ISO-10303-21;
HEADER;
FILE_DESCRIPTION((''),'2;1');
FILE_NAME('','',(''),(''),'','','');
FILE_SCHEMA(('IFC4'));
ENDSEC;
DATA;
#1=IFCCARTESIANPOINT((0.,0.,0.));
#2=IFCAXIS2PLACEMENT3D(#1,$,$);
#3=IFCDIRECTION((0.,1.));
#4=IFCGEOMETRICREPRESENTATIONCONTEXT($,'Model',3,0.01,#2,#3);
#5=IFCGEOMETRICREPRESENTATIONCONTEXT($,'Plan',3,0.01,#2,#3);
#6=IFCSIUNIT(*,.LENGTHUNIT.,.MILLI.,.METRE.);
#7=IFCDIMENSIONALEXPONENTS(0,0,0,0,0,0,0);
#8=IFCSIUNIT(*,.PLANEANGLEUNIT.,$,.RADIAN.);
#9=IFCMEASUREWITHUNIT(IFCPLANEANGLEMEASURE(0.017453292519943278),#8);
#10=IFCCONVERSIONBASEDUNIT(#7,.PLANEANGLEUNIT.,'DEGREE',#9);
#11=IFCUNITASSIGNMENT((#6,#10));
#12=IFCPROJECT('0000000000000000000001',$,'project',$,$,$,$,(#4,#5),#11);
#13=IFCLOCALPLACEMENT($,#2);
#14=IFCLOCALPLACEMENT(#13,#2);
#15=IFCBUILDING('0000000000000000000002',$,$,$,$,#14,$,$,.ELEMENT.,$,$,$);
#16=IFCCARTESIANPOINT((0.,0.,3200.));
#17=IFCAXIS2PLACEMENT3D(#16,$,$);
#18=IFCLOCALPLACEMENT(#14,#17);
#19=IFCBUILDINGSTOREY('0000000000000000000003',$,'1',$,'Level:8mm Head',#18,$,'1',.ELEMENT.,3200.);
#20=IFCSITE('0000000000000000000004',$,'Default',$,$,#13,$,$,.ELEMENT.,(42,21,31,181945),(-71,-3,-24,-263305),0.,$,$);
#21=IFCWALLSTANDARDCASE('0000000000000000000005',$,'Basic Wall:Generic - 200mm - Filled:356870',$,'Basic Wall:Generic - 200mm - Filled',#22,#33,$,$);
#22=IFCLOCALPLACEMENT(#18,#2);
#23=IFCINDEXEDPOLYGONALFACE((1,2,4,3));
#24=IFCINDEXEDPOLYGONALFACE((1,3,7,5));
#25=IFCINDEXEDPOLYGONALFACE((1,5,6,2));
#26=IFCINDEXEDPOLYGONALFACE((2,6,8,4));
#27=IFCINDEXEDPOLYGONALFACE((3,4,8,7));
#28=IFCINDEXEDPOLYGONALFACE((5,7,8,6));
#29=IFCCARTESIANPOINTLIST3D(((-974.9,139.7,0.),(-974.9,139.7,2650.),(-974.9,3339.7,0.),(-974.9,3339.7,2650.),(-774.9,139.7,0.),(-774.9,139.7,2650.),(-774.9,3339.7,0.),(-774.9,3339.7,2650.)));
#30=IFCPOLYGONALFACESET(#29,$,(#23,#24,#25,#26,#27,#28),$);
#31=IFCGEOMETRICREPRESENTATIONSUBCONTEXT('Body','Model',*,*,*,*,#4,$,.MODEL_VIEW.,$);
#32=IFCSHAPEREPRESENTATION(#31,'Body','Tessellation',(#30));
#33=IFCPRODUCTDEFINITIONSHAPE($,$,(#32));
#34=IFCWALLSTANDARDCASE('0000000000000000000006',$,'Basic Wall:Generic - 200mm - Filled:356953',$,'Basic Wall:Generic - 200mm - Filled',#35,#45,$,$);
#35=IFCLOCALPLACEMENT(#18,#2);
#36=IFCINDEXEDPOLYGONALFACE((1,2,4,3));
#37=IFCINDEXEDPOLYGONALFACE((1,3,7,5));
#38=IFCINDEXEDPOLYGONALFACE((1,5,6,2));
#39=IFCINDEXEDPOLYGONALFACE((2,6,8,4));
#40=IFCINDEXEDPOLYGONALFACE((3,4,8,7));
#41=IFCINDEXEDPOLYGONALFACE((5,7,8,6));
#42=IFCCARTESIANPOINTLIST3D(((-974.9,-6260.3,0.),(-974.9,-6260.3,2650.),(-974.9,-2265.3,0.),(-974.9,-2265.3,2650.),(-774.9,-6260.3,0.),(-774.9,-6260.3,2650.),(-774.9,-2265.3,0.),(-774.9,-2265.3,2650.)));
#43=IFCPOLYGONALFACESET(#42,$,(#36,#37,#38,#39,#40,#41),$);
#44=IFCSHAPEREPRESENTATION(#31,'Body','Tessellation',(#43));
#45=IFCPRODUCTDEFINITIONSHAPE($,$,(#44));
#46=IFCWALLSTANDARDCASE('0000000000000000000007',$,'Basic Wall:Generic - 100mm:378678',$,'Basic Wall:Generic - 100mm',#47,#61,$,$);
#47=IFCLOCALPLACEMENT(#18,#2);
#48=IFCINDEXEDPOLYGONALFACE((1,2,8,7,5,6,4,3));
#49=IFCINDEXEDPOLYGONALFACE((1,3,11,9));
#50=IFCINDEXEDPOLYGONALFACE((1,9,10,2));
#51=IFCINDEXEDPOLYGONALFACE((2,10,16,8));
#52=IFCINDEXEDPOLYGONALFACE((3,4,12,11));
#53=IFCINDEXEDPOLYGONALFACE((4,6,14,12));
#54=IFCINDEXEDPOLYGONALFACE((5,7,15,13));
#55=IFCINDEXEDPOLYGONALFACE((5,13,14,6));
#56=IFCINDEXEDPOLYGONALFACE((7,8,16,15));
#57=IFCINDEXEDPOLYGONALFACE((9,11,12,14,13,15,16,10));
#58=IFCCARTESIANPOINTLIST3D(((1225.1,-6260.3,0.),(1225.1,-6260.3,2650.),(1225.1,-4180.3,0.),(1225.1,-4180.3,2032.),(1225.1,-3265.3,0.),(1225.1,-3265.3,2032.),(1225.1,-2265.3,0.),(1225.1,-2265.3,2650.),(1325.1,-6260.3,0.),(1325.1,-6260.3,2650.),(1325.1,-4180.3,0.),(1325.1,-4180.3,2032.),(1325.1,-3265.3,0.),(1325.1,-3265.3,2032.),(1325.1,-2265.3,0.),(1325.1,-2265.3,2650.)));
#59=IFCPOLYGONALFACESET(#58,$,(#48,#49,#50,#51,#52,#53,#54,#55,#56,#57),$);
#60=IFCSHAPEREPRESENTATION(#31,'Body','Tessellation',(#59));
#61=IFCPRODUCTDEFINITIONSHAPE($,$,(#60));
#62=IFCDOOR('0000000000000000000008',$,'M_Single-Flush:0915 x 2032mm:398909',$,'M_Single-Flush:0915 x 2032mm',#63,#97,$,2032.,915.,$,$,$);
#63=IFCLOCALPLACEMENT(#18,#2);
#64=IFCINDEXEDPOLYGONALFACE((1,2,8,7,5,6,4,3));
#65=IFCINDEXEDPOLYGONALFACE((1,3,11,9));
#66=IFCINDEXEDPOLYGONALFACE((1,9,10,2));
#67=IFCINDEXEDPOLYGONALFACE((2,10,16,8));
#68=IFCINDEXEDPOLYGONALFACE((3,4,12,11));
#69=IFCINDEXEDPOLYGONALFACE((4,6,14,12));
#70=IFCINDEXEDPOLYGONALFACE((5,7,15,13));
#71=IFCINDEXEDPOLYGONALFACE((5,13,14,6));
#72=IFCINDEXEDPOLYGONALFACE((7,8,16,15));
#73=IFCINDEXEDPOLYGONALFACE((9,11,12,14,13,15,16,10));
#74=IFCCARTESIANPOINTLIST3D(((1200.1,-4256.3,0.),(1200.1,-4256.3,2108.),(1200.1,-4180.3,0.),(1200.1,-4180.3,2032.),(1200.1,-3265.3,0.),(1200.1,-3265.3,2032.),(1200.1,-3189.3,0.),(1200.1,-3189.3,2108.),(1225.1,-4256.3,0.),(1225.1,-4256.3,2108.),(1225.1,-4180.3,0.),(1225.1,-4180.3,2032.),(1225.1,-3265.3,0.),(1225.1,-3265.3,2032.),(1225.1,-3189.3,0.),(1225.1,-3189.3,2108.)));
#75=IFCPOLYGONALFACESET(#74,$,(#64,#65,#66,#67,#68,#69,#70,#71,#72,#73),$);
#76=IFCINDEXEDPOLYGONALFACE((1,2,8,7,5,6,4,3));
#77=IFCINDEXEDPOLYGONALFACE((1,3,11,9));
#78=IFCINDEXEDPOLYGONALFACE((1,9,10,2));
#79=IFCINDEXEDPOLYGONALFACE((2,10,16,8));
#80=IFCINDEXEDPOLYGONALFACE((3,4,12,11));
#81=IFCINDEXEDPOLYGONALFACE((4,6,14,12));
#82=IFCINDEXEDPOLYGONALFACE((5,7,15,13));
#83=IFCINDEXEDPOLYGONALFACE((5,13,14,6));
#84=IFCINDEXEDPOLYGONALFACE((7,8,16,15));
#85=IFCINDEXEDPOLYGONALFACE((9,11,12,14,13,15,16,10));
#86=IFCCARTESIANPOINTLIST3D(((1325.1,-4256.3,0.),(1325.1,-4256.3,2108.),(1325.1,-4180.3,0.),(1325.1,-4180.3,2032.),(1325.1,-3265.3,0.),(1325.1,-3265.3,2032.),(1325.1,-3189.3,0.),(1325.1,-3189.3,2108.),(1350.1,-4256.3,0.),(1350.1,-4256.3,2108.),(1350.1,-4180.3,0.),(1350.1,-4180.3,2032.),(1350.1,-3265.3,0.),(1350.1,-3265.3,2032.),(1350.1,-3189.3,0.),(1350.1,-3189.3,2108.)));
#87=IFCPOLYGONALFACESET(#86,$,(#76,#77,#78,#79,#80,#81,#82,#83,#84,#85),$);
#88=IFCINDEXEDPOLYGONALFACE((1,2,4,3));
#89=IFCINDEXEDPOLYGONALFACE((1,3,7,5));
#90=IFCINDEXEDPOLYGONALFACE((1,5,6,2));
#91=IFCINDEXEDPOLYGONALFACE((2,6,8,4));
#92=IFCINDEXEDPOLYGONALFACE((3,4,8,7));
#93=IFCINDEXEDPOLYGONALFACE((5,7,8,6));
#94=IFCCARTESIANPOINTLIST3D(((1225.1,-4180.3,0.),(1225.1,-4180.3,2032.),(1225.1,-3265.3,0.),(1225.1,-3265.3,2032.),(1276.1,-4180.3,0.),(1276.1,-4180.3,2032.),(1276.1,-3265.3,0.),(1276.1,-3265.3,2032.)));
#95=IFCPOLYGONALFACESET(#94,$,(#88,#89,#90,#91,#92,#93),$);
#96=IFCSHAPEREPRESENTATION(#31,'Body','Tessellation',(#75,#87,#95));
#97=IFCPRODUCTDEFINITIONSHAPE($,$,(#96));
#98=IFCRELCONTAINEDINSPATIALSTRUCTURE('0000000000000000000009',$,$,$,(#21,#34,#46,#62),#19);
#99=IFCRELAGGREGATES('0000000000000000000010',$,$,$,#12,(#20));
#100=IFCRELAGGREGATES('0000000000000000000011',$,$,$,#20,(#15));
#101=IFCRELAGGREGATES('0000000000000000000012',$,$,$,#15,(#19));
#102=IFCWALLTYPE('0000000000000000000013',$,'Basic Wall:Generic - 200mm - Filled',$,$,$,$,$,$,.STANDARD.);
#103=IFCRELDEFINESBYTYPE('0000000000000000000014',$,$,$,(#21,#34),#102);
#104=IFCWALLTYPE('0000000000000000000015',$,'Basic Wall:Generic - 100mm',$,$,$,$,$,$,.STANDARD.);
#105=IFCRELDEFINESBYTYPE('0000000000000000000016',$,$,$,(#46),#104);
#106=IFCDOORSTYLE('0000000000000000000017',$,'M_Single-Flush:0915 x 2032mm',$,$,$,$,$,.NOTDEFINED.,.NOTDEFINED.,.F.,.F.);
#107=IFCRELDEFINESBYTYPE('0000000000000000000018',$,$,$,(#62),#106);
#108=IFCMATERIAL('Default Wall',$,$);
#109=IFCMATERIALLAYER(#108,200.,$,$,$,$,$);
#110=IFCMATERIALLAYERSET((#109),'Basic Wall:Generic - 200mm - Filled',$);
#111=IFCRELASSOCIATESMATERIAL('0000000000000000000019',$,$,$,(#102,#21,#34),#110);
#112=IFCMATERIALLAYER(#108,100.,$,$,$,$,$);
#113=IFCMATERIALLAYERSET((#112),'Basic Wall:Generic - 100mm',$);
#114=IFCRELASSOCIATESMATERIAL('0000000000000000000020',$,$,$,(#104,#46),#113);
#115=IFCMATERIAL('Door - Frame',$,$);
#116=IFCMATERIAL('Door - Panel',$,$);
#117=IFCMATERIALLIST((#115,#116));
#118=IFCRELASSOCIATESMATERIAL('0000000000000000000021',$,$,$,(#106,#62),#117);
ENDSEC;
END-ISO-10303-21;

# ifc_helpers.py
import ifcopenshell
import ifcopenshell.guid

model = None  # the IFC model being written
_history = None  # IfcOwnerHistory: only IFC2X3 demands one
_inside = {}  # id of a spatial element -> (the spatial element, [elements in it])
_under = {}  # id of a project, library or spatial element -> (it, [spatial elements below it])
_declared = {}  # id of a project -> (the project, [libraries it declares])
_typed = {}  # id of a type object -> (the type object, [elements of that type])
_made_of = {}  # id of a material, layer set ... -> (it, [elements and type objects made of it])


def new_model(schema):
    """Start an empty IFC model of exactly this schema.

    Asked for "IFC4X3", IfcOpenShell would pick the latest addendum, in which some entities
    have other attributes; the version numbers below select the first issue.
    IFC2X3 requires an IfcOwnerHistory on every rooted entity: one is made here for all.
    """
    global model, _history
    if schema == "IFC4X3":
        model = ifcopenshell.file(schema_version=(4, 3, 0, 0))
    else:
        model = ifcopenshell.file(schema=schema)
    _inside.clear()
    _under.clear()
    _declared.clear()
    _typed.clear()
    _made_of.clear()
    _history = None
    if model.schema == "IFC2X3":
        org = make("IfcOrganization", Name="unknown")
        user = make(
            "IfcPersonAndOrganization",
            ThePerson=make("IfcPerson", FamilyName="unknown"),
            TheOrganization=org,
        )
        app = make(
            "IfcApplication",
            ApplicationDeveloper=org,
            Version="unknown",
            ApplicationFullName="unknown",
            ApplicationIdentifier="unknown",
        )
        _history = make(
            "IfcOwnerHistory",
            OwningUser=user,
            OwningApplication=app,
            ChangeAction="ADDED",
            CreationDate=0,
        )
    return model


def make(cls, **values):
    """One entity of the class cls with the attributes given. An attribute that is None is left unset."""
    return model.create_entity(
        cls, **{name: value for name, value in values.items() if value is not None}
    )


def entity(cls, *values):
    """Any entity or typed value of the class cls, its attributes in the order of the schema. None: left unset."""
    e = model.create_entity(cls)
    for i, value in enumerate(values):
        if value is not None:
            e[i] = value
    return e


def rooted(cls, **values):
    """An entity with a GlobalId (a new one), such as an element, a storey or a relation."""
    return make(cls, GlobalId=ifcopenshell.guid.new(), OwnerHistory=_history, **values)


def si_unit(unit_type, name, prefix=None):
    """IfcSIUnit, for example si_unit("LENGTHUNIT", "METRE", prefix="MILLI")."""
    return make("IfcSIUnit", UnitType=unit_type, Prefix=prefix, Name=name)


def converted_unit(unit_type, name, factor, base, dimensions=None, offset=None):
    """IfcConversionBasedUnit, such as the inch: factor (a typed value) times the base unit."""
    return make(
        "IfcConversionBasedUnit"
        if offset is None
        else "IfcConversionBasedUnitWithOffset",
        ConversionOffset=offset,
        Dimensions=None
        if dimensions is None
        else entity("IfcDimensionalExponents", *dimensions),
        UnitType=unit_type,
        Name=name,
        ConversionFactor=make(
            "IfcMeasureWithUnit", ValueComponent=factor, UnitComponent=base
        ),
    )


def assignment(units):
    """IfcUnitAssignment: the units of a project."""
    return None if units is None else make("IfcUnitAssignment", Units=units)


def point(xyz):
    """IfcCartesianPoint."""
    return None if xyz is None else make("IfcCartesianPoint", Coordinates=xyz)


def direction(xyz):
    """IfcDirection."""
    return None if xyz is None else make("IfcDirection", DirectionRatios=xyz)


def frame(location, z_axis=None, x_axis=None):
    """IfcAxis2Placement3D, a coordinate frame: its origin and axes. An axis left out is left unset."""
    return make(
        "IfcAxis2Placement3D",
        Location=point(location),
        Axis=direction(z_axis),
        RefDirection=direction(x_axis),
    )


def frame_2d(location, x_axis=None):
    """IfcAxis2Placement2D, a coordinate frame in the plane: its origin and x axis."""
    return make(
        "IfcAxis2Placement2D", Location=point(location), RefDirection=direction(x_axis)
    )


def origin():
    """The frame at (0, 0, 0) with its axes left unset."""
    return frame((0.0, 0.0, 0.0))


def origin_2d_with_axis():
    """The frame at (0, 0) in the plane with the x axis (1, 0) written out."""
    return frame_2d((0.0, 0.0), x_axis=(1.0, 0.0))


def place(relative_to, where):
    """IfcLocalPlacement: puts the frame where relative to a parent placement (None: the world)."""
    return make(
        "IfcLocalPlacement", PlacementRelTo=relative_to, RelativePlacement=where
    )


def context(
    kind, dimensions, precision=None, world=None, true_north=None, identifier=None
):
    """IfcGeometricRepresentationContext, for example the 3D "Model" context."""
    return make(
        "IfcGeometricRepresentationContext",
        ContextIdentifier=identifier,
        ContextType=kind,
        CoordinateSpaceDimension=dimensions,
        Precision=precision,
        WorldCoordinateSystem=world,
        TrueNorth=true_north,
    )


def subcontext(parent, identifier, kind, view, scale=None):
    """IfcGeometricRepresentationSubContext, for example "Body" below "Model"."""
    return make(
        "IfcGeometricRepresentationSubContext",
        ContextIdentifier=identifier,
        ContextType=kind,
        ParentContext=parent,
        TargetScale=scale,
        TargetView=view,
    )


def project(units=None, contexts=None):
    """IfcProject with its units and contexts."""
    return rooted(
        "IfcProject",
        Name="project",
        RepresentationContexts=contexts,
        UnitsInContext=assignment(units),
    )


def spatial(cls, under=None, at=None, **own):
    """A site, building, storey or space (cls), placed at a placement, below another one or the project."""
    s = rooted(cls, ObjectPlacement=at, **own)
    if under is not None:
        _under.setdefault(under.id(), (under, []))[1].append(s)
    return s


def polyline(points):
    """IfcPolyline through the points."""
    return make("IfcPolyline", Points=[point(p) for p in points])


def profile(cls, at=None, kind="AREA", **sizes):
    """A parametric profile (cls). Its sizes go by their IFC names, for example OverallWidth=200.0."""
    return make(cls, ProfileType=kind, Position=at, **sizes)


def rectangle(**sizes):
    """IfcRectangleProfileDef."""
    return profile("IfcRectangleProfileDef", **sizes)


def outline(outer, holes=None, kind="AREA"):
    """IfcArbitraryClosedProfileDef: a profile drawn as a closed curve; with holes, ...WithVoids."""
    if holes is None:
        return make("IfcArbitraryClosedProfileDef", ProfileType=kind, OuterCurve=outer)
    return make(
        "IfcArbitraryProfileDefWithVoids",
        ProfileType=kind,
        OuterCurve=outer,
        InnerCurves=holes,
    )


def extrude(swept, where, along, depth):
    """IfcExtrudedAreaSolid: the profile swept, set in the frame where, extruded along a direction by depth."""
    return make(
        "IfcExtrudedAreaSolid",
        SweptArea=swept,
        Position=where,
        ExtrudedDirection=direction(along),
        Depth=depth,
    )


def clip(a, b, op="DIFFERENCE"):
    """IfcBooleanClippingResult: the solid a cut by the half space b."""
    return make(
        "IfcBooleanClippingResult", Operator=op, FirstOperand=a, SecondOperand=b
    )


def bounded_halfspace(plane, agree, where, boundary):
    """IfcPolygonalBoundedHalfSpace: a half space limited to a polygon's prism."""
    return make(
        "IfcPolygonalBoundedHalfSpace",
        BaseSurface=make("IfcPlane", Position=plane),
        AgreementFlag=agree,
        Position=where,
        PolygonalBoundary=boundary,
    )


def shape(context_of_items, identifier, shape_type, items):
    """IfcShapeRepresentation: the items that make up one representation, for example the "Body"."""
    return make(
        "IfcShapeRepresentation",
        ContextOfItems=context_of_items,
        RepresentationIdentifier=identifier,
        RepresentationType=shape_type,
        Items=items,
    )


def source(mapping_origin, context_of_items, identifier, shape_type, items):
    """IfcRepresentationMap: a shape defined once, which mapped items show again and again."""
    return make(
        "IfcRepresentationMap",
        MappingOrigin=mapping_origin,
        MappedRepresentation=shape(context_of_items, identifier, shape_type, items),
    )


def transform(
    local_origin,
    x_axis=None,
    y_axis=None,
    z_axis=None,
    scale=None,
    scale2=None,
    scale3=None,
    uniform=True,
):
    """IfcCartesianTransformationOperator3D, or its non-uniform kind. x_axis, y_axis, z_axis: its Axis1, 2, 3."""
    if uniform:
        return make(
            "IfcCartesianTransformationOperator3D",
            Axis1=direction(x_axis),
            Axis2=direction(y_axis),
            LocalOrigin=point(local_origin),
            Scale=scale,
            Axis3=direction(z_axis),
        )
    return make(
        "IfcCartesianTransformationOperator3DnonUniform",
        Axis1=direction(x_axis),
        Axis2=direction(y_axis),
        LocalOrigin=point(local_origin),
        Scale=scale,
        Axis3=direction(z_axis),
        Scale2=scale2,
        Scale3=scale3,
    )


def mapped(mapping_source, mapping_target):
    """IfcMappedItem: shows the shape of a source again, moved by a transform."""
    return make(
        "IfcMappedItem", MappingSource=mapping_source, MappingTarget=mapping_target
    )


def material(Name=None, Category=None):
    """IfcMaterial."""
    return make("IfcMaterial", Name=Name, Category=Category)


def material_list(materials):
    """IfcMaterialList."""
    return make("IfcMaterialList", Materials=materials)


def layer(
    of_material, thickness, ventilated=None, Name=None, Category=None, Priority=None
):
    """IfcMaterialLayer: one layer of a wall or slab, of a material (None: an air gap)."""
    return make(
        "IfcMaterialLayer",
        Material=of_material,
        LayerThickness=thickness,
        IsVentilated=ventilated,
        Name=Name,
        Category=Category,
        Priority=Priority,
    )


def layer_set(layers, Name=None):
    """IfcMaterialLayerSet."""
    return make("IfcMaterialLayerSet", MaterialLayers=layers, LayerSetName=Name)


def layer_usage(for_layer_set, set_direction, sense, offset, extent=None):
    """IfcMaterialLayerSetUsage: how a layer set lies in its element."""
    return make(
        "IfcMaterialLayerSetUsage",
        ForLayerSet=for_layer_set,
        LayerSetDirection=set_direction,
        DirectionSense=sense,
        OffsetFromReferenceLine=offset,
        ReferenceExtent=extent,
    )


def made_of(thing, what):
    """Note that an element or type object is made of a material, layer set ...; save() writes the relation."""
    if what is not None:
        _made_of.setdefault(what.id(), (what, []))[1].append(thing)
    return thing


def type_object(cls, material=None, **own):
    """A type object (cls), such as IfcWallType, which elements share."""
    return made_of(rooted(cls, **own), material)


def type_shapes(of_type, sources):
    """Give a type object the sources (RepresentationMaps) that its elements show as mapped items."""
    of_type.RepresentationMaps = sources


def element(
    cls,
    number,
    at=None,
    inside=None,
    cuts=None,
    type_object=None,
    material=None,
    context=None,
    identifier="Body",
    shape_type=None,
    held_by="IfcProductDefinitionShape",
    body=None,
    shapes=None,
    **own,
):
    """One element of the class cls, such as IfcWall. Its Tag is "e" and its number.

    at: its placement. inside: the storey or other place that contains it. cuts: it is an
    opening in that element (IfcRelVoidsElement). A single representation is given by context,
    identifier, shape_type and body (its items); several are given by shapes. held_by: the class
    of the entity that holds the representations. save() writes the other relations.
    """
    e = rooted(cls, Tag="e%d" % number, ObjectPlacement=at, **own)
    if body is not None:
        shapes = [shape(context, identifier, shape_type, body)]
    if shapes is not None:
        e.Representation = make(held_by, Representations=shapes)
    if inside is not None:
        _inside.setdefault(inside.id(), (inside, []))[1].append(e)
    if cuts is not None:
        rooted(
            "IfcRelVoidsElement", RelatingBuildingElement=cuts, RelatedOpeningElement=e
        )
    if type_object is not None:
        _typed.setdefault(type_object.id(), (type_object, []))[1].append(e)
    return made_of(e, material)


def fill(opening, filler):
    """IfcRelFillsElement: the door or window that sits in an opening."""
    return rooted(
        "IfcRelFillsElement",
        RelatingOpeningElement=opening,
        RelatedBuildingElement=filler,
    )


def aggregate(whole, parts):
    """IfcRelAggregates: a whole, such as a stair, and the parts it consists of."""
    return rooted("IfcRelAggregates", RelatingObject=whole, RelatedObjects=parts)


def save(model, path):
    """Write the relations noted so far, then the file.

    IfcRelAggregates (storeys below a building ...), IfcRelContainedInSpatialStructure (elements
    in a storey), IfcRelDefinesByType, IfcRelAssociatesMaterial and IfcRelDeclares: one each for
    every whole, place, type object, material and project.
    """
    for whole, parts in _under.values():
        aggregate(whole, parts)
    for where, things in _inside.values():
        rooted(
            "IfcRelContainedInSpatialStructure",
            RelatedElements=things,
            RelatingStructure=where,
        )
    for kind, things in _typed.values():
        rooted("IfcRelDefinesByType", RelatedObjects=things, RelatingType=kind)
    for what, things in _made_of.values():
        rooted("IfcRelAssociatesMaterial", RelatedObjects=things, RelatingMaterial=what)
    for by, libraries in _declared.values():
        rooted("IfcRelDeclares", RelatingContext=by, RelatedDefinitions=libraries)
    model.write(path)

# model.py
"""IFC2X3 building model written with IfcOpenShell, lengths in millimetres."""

from ifc_helpers import new_model, entity, si_unit, converted_unit, direction, frame, frame_2d, origin, origin_2d_with_axis, place, context, subcontext, project, spatial, polyline, rectangle, outline, extrude, clip, bounded_halfspace, source, transform, mapped, material, material_list, layer, layer_set, layer_usage, type_object, type_shapes, element, fill, save


model = new_model("IFC2X3")

# Units and contexts
model_context = context("Model", 3, precision=0.01, world=origin(), true_north=direction((0.0, 1.0)))
plan_context = context("Plan", 3, precision=0.01, world=origin(), true_north=direction((0.0, 1.0)))
body_context = subcontext(model_context, "Body", "Model", "MODEL_VIEW")
ifc_project = project(units=[si_unit("LENGTHUNIT", "METRE", prefix="MILLI"), converted_unit("PLANEANGLEUNIT", "DEGREE", entity("IfcPlaneAngleMeasure", 0.017453292519943278), si_unit("PLANEANGLEUNIT", "RADIAN"), dimensions=[0, 0, 0, 0, 0, 0, 0])], contexts=[model_context, plan_context])

# Site, building, storey
site_placement = place(None, origin())
site = spatial("IfcSite", under=ifc_project, at=site_placement, Name="Default", CompositionType="ELEMENT", RefLatitude=(42, 21, 31, 181945), RefLongitude=(-71, -3, -24, -263305), RefElevation=0.0)
building_placement = place(site_placement, origin())
building = spatial("IfcBuilding", under=site, at=building_placement, CompositionType="ELEMENT")
storey_placement = place(building_placement, frame((0.0, 0.0, 3200.0)))
storey = spatial("IfcBuildingStorey", under=building, at=storey_placement, Name="1", ObjectType="Level:8mm Head", LongName="1", CompositionType="ELEMENT", Elevation=3200.0)

# Shared definitions
ifc_material_1 = material(Name="Default Wall")
ifc_layer_1 = layer(ifc_material_1, 200.0)
ifc_layer_set_1 = layer_set([ifc_layer_1], Name="Basic Wall:Generic - 200mm - Filled")
ifc_layer_usage_1 = layer_usage(ifc_layer_set_1, "AXIS2", "NEGATIVE", 100.0)
wall_type_1 = type_object("IfcWallType", Name="Basic Wall:Generic - 200mm - Filled", PredefinedType="STANDARD", material=ifc_layer_set_1)
ifc_material_2 = material(Name="Door - Frame")
ifc_material_3 = material(Name="Door - Panel")
ifc_material_list = material_list([ifc_material_2, ifc_material_3])

# Walls
wall_1_placement = place(storey_placement, frame((-874.9, 3339.7, 0.0), z_axis=(0.0, 0.0, 1.0), x_axis=(0.0, -1.0, 0.0)))
element("IfcWallStandardCase", 1, at=wall_1_placement, inside=storey, type_object=wall_type_1, material=ifc_layer_usage_1, Name="Basic Wall:Generic - 200mm - Filled:356870", ObjectType="Basic Wall:Generic - 200mm - Filled", context=body_context, shape_type="Clipping", body=[
    clip(extrude(rectangle(XDim=3200.0, YDim=200.0, at=frame_2d((1600.0, 0.0), x_axis=(-1.0, 0.0))), origin(), (0.0, 0.0, 1.0), 2650.0), bounded_halfspace(frame((0.0, -100.0, 2650.0), z_axis=(0.0, 0.0, -1.0), x_axis=(1.0, 0.0, 0.0)), True, frame((0.0, -100.0, 2650.0)), polyline([(0.0, 0.0), (3200.0, 0.0), (3200.0, 200.0), (0.0, 200.0), (0.0, 0.0)]))),
])
wall_2_placement = place(storey_placement, frame((-874.9, -2265.3, 0.0), z_axis=(0.0, 0.0, 1.0), x_axis=(0.0, -1.0, 0.0)))
element("IfcWallStandardCase", 2, at=wall_2_placement, inside=storey, type_object=wall_type_1, material=ifc_layer_usage_1, Name="Basic Wall:Generic - 200mm - Filled:356953", ObjectType="Basic Wall:Generic - 200mm - Filled", context=body_context, shape_type="Clipping", body=[
    clip(extrude(rectangle(XDim=3995.0, YDim=200.0, at=frame_2d((1997.5, 0.0), x_axis=(-1.0, 0.0))), origin(), (0.0, 0.0, 1.0), 2650.0), bounded_halfspace(frame((3995.0, 0.0, 2650.0), z_axis=(0.0, 0.0, -1.0), x_axis=(1.0, 0.0, 0.0)), True, frame((3995.0, 0.0, 2650.0)), polyline([(0.0, 0.0), (0.0, 100.0), (-3995.0, 100.0), (-3995.0, 0.0), (-3995.0, -100.0), (-2995.0, -100.0), (-2995.0, 0.0), (0.0, 0.0)]))),
])

# Wall, opening, door
ifc_layer_2 = layer(ifc_material_1, 100.0)
ifc_layer_set_2 = layer_set([ifc_layer_2], Name="Basic Wall:Generic - 100mm")
ifc_layer_usage_2 = layer_usage(ifc_layer_set_2, "AXIS2", "NEGATIVE", 50.0)
wall_type_2 = type_object("IfcWallType", Name="Basic Wall:Generic - 100mm", PredefinedType="STANDARD", material=ifc_layer_set_2)
wall_3_placement = place(storey_placement, frame((1275.1, -2265.3, 0.0), z_axis=(0.0, 0.0, 1.0), x_axis=(0.0, -1.0, 0.0)))
wall_3 = element("IfcWallStandardCase", 3, at=wall_3_placement, inside=storey, type_object=wall_type_2, material=ifc_layer_usage_2, Name="Basic Wall:Generic - 100mm:378678", ObjectType="Basic Wall:Generic - 100mm", context=body_context, shape_type="Clipping", body=[
    clip(extrude(rectangle(XDim=3995.0, YDim=100.0, at=frame_2d((1997.5, 0.0), x_axis=(-1.0, 0.0))), origin(), (0.0, 0.0, 1.0), 2650.0), bounded_halfspace(frame((0.0, -50.0, 2650.0), z_axis=(0.0, 0.0, -1.0), x_axis=(1.0, 0.0, 0.0)), True, frame((0.0, -50.0, 2650.0)), polyline([(0.0, 0.0), (3995.0, 0.0), (3995.0, 100.0), (0.0, 100.0), (0.0, 0.0)]))),
])
opening_1_placement = place(wall_3_placement, frame((1915.0, 50.0, 0.0)))
opening_1 = element("IfcOpeningElement", 4, at=opening_1_placement, cuts=wall_3, ObjectType="Opening", context=body_context, shape_type="SweptSolid", body=[
    extrude(rectangle(XDim=915.0, YDim=2032.0, at=frame_2d((1016.0, 457.5), x_axis=(0.0, 1.0))), frame((0.0, 0.0, 0.0), z_axis=(0.0, -1.0, 0.0), x_axis=(0.0, 0.0, 1.0)), (0.0, 0.0, 1.0), 100.0),
])
door_style_1 = type_object("IfcDoorStyle", Name="M_Single-Flush:0915 x 2032mm", ConstructionType="NOTDEFINED", OperationType="NOTDEFINED", ParameterTakesPrecedence=False, Sizeable=False, material=ifc_material_list)
shared_shape_1 = source(origin(), body_context, "Body", "SweptSolid", [
    extrude(outline(polyline([(-533.5, -1073.0), (533.5, -1073.0), (533.5, 1035.0), (457.5, 1035.0), (457.5, -997.0), (-457.5, -997.0), (-457.5, 1035.0), (-533.5, 1035.0), (-533.5, -1073.0)])), frame((457.5, 100.0, 1035.0), z_axis=(0.0, 1.0, 0.0), x_axis=(1.0, 0.0, 0.0)), (0.0, 0.0, 1.0), 25.0),
    extrude(outline(polyline([(-1073.0, -533.5), (1035.0, -533.5), (1035.0, -457.5), (-997.0, -457.5), (-997.0, 457.5), (1035.0, 457.5), (1035.0, 533.5), (-1073.0, 533.5), (-1073.0, -533.5)])), frame((457.5, -25.0, 1035.0), z_axis=(0.0, 1.0, 0.0), x_axis=(0.0, 0.0, -1.0)), (0.0, 0.0, 1.0), 25.0),
    extrude(rectangle(XDim=51.0, YDim=915.0, at=origin_2d_with_axis()), frame((457.5, 74.5, 0.0), z_axis=(0.0, 0.0, 1.0), x_axis=(0.0, 1.0, 0.0)), (0.0, 0.0, 1.0), 2032.0),
])
type_shapes(door_style_1, [shared_shape_1])
door_1_placement = place(opening_1_placement, frame((0.0, 0.0, 0.0), z_axis=(0.0, 0.0, 1.0), x_axis=(-1.0, 0.0, 0.0)))
door_1 = element("IfcDoor", 5, at=door_1_placement, inside=storey, type_object=door_style_1, material=ifc_material_list, Name="M_Single-Flush:0915 x 2032mm:398909", ObjectType="M_Single-Flush:0915 x 2032mm", OverallHeight=2032.0, OverallWidth=915.0, context=body_context, shape_type="MappedRepresentation", body=[
    mapped(shared_shape_1, transform((0.0, 0.0, 0.0), scale=1.0)),
])
fill(opening_1, door_1)

save(model, "model.ifc")
